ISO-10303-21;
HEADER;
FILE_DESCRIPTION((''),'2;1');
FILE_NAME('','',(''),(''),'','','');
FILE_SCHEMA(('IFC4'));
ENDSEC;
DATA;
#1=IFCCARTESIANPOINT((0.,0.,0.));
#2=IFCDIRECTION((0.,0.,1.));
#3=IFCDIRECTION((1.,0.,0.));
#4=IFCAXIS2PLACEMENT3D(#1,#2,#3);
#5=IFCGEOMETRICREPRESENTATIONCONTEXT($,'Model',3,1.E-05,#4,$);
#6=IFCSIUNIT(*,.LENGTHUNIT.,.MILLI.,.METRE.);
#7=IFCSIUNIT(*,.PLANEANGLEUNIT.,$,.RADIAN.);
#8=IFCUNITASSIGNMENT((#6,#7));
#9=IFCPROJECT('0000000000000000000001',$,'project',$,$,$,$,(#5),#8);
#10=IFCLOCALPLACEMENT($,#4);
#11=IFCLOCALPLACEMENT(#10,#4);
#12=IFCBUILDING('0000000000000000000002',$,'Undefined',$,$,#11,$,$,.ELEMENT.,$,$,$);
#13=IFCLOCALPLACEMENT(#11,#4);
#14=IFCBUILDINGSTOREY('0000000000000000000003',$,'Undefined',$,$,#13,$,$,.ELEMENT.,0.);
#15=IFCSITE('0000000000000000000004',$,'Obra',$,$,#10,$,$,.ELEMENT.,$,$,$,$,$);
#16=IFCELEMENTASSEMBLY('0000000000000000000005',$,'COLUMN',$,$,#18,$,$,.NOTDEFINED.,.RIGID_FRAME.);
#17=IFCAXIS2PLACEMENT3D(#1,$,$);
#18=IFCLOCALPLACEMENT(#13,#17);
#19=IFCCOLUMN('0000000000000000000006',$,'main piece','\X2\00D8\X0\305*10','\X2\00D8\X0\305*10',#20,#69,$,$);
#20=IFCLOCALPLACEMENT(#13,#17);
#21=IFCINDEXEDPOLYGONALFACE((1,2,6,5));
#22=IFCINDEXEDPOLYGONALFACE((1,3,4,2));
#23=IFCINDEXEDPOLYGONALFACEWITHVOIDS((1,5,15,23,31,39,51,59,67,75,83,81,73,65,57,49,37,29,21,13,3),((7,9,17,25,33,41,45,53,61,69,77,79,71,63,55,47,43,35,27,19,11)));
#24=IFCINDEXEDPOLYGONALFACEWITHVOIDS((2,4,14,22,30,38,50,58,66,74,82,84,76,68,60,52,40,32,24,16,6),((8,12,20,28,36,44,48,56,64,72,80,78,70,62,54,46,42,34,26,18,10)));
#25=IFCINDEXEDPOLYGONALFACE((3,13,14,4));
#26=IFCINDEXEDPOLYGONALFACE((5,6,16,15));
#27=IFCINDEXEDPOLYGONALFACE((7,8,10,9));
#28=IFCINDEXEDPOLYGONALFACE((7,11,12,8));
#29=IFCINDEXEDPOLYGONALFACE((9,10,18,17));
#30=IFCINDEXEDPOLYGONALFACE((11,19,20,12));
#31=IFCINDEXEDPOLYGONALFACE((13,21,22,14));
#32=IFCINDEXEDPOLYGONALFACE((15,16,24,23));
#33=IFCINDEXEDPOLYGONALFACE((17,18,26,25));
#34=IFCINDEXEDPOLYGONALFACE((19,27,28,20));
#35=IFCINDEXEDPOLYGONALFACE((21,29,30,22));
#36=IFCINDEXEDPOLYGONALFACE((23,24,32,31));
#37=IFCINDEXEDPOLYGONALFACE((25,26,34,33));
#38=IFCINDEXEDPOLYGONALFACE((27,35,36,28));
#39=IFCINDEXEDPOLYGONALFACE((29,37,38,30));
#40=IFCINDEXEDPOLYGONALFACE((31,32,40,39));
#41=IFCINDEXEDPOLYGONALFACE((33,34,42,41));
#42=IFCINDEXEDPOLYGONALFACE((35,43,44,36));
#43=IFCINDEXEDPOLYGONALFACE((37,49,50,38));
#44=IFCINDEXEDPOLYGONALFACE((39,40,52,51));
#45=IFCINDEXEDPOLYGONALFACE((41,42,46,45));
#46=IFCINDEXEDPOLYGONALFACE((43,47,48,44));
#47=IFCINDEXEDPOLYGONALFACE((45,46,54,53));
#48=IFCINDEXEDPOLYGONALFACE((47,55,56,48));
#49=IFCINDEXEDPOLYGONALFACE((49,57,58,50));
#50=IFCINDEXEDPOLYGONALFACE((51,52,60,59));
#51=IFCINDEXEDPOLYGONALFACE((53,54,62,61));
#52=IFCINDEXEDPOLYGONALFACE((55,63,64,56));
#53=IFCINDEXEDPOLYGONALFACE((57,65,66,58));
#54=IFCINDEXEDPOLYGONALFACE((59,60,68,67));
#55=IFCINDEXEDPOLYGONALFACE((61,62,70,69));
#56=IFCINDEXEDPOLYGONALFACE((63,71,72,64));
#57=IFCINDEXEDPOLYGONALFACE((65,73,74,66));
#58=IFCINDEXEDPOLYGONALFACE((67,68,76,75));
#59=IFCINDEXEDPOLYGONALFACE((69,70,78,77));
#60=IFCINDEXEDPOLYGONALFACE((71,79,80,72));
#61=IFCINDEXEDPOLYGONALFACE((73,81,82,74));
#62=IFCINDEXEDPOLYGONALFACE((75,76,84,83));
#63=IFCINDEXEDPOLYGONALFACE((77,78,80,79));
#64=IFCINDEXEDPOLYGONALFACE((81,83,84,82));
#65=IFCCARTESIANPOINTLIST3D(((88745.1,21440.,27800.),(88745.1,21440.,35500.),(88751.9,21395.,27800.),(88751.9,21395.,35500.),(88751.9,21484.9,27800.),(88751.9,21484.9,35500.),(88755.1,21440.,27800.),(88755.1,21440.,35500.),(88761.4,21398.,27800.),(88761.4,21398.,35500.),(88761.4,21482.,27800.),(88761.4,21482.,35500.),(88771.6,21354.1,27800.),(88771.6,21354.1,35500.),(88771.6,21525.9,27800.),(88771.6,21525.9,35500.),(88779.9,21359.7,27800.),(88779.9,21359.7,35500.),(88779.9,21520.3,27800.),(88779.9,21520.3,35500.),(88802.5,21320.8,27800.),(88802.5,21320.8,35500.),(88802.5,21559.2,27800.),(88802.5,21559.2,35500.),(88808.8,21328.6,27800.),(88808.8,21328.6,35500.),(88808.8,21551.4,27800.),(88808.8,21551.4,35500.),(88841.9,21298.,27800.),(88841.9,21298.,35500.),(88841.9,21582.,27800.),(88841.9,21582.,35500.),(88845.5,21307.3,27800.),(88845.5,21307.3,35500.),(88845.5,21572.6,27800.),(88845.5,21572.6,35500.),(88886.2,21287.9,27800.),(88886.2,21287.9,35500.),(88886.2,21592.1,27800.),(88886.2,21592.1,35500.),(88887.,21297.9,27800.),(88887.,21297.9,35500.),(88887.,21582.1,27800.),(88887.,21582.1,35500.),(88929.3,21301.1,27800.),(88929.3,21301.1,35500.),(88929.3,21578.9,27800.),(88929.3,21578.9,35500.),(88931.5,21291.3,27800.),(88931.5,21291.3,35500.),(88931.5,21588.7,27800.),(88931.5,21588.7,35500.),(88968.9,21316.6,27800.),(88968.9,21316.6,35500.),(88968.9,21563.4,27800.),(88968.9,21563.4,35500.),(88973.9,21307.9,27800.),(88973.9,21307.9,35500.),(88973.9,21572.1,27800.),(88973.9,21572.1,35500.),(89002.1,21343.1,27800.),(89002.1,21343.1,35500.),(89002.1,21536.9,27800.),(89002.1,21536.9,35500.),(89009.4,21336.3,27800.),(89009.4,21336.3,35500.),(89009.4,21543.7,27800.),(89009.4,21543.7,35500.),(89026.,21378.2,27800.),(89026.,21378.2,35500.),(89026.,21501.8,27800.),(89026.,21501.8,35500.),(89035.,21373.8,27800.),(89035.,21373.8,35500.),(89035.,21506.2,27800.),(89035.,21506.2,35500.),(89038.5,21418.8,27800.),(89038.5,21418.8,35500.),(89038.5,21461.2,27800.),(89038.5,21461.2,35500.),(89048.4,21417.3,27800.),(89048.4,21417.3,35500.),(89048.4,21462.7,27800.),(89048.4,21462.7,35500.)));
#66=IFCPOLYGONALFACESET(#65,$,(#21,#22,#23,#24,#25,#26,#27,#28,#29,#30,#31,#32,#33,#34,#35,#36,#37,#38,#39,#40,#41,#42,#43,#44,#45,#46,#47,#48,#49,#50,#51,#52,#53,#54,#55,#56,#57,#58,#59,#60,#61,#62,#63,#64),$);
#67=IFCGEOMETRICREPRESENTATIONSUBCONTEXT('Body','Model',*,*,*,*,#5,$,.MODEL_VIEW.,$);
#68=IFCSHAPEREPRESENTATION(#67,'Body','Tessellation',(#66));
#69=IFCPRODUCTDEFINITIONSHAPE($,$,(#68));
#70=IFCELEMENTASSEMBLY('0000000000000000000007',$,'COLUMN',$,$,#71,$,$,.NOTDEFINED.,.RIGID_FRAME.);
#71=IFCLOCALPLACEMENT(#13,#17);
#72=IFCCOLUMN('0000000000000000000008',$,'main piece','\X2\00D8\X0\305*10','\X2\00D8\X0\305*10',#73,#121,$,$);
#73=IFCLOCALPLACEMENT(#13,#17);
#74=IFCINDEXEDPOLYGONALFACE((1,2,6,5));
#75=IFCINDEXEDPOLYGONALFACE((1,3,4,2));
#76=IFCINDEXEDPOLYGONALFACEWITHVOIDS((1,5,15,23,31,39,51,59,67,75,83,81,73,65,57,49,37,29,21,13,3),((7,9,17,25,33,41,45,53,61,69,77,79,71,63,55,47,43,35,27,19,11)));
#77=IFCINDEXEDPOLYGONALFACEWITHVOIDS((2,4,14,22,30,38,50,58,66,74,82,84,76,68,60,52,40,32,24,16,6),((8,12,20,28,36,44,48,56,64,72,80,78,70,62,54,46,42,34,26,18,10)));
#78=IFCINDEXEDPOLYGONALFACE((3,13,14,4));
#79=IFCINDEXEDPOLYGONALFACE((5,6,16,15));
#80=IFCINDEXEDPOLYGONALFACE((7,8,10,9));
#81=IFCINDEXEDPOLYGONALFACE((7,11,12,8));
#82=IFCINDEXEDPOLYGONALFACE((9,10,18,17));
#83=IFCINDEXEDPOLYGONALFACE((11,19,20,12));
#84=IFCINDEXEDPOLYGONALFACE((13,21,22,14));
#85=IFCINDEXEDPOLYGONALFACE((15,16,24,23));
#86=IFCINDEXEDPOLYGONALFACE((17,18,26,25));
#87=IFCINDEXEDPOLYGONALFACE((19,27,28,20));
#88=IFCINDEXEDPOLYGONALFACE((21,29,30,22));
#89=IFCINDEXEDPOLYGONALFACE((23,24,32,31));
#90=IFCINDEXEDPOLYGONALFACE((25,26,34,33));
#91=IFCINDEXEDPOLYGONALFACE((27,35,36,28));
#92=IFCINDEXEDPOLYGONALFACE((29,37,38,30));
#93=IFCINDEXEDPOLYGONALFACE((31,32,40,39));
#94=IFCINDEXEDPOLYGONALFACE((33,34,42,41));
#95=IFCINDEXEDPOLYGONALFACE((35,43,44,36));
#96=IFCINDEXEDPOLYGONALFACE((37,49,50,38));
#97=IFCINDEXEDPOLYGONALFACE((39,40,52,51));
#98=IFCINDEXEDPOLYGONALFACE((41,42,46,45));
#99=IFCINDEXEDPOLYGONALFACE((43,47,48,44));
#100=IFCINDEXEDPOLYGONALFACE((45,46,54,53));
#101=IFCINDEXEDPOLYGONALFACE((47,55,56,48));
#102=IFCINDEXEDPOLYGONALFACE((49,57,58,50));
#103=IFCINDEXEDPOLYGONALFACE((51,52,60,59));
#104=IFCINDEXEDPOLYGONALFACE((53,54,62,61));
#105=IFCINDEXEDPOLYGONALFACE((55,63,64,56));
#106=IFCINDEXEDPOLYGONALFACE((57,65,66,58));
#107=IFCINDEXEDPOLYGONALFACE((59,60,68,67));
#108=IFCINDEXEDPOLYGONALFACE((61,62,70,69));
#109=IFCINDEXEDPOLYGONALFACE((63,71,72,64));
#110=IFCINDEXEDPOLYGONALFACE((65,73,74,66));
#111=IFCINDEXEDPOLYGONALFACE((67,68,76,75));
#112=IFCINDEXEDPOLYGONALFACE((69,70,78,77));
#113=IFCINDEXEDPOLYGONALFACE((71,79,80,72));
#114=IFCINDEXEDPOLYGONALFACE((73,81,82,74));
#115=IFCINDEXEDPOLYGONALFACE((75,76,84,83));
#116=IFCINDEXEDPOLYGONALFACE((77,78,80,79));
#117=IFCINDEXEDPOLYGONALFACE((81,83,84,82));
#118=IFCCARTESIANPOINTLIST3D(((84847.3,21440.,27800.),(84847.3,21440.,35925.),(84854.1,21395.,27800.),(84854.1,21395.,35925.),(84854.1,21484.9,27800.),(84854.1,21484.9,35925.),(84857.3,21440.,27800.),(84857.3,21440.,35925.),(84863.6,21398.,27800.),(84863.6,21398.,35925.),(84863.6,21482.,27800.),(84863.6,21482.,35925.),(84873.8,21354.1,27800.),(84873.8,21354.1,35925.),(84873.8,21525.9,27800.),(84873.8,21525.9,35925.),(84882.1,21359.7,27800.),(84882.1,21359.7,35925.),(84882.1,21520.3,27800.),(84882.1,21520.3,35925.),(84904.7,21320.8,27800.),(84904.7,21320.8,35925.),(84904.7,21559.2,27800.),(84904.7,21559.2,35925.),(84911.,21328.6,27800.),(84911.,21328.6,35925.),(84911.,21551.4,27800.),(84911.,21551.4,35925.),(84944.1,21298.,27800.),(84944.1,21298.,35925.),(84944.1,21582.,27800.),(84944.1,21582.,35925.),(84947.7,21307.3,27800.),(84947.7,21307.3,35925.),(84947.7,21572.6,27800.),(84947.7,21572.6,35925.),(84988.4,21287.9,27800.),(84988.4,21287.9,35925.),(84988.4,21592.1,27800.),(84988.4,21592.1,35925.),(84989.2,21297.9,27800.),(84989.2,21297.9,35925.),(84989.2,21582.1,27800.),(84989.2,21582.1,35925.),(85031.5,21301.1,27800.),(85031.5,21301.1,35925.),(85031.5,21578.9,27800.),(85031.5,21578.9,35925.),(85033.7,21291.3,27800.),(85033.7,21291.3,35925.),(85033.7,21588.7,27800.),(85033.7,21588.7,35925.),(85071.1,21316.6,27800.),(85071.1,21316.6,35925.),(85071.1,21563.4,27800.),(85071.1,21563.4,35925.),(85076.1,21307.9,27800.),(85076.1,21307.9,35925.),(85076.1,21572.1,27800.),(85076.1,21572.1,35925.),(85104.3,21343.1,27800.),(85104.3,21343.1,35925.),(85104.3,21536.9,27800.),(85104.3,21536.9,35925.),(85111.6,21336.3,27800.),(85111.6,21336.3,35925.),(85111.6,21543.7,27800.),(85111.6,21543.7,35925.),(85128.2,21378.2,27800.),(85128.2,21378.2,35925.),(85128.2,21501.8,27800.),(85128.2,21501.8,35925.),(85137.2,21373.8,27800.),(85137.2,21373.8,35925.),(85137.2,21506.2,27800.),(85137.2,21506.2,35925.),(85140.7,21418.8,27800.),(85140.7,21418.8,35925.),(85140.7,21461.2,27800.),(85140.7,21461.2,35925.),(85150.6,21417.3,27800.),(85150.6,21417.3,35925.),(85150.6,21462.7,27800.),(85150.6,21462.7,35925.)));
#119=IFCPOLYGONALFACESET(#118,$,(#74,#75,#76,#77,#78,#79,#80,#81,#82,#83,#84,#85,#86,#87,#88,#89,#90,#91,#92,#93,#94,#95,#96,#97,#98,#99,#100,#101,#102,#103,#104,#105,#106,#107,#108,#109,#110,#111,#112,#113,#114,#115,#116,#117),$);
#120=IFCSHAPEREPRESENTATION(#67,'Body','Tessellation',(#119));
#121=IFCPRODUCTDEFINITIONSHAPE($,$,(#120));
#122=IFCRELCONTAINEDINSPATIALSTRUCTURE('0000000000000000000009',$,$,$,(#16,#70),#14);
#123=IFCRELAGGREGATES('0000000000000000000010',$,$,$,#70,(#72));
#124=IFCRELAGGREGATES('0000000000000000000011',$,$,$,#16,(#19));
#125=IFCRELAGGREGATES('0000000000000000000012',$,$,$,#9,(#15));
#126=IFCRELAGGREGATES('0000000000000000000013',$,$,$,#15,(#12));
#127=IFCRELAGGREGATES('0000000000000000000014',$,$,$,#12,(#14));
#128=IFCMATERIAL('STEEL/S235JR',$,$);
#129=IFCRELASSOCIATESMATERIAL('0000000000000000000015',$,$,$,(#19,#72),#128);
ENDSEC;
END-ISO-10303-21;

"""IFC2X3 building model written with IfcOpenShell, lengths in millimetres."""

from ifc_helpers import new_model, si_unit, frame, origin_with_axes, origin_2d_with_axis, place, context, subcontext, project, spatial, hollow_circle, extrude, material, element, aggregate, save


model = new_model("IFC2X3")

# Units and contexts
model_context = context("Model", 3, precision=1e-05, world=origin_with_axes())
body_context = subcontext(model_context, "Body", "Model", "MODEL_VIEW")
ifc_project = project(units=[si_unit("LENGTHUNIT", "METRE", prefix="MILLI"), si_unit("PLANEANGLEUNIT", "RADIAN")], contexts=[model_context])

# Site, building, storey
site_placement = place(None, origin_with_axes())
site = spatial("IfcSite", under=ifc_project, at=site_placement, Name="Obra", CompositionType="ELEMENT")
building_placement = place(site_placement, origin_with_axes())
building = spatial("IfcBuilding", under=site, at=building_placement, Name="Undefined", CompositionType="ELEMENT")
storey_placement = place(building_placement, origin_with_axes())
storey = spatial("IfcBuildingStorey", under=building, at=storey_placement, Name="Undefined", CompositionType="ELEMENT", Elevation=0.0)

# Element assemblies, columns
assembly_1_placement = place(storey_placement, origin_with_axes())
assembly_1 = element("IfcElementAssembly", 1, at=assembly_1_placement, inside=storey, Name="COLUMN", AssemblyPlace="NOTDEFINED", PredefinedType="RIGID_FRAME")
ifc_material = material(Name="STEEL/S235JR")
column_1_placement = place(assembly_1_placement, frame((88897.6, 21440.0, 27800.0), z_axis=(0.0, 0.0, 1.0), x_axis=(0.0, 1.0, 0.0)))
column_1 = element("IfcColumn", 2, at=column_1_placement, material=ifc_material, Name="main piece", Description="Ø305*10", ObjectType="Ø305*10", context=body_context, shape_type="SweptSolid", body=[
    extrude(hollow_circle(Radius=152.5, WallThickness=10.0, at=origin_2d_with_axis()), frame((0.0, 0.0, 7700.0), z_axis=(0.0, 0.0, -1.0), x_axis=(0.0, 1.0, 0.0)), (0.0, 0.0, 1.0), 7700.0),
])
assembly_2_placement = place(storey_placement, origin_with_axes())
assembly_2 = element("IfcElementAssembly", 3, at=assembly_2_placement, inside=storey, Name="COLUMN", AssemblyPlace="NOTDEFINED", PredefinedType="RIGID_FRAME")
column_2_placement = place(assembly_2_placement, frame((84999.8, 21440.0, 27800.0), z_axis=(0.0, 0.0, 1.0), x_axis=(0.0, 1.0, 0.0)))
column_2 = element("IfcColumn", 4, at=column_2_placement, material=ifc_material, Name="main piece", Description="Ø305*10", ObjectType="Ø305*10", context=body_context, shape_type="SweptSolid", body=[
    extrude(hollow_circle(Radius=152.5, WallThickness=10.0, at=origin_2d_with_axis()), frame((0.0, 0.0, 8125.0), z_axis=(0.0, 0.0, -1.0), x_axis=(0.0, 1.0, 0.0)), (0.0, 0.0, 1.0), 8125.0),
])

aggregate(assembly_2, [column_2])
aggregate(assembly_1, [column_1])

save(model, "model.ifc")
